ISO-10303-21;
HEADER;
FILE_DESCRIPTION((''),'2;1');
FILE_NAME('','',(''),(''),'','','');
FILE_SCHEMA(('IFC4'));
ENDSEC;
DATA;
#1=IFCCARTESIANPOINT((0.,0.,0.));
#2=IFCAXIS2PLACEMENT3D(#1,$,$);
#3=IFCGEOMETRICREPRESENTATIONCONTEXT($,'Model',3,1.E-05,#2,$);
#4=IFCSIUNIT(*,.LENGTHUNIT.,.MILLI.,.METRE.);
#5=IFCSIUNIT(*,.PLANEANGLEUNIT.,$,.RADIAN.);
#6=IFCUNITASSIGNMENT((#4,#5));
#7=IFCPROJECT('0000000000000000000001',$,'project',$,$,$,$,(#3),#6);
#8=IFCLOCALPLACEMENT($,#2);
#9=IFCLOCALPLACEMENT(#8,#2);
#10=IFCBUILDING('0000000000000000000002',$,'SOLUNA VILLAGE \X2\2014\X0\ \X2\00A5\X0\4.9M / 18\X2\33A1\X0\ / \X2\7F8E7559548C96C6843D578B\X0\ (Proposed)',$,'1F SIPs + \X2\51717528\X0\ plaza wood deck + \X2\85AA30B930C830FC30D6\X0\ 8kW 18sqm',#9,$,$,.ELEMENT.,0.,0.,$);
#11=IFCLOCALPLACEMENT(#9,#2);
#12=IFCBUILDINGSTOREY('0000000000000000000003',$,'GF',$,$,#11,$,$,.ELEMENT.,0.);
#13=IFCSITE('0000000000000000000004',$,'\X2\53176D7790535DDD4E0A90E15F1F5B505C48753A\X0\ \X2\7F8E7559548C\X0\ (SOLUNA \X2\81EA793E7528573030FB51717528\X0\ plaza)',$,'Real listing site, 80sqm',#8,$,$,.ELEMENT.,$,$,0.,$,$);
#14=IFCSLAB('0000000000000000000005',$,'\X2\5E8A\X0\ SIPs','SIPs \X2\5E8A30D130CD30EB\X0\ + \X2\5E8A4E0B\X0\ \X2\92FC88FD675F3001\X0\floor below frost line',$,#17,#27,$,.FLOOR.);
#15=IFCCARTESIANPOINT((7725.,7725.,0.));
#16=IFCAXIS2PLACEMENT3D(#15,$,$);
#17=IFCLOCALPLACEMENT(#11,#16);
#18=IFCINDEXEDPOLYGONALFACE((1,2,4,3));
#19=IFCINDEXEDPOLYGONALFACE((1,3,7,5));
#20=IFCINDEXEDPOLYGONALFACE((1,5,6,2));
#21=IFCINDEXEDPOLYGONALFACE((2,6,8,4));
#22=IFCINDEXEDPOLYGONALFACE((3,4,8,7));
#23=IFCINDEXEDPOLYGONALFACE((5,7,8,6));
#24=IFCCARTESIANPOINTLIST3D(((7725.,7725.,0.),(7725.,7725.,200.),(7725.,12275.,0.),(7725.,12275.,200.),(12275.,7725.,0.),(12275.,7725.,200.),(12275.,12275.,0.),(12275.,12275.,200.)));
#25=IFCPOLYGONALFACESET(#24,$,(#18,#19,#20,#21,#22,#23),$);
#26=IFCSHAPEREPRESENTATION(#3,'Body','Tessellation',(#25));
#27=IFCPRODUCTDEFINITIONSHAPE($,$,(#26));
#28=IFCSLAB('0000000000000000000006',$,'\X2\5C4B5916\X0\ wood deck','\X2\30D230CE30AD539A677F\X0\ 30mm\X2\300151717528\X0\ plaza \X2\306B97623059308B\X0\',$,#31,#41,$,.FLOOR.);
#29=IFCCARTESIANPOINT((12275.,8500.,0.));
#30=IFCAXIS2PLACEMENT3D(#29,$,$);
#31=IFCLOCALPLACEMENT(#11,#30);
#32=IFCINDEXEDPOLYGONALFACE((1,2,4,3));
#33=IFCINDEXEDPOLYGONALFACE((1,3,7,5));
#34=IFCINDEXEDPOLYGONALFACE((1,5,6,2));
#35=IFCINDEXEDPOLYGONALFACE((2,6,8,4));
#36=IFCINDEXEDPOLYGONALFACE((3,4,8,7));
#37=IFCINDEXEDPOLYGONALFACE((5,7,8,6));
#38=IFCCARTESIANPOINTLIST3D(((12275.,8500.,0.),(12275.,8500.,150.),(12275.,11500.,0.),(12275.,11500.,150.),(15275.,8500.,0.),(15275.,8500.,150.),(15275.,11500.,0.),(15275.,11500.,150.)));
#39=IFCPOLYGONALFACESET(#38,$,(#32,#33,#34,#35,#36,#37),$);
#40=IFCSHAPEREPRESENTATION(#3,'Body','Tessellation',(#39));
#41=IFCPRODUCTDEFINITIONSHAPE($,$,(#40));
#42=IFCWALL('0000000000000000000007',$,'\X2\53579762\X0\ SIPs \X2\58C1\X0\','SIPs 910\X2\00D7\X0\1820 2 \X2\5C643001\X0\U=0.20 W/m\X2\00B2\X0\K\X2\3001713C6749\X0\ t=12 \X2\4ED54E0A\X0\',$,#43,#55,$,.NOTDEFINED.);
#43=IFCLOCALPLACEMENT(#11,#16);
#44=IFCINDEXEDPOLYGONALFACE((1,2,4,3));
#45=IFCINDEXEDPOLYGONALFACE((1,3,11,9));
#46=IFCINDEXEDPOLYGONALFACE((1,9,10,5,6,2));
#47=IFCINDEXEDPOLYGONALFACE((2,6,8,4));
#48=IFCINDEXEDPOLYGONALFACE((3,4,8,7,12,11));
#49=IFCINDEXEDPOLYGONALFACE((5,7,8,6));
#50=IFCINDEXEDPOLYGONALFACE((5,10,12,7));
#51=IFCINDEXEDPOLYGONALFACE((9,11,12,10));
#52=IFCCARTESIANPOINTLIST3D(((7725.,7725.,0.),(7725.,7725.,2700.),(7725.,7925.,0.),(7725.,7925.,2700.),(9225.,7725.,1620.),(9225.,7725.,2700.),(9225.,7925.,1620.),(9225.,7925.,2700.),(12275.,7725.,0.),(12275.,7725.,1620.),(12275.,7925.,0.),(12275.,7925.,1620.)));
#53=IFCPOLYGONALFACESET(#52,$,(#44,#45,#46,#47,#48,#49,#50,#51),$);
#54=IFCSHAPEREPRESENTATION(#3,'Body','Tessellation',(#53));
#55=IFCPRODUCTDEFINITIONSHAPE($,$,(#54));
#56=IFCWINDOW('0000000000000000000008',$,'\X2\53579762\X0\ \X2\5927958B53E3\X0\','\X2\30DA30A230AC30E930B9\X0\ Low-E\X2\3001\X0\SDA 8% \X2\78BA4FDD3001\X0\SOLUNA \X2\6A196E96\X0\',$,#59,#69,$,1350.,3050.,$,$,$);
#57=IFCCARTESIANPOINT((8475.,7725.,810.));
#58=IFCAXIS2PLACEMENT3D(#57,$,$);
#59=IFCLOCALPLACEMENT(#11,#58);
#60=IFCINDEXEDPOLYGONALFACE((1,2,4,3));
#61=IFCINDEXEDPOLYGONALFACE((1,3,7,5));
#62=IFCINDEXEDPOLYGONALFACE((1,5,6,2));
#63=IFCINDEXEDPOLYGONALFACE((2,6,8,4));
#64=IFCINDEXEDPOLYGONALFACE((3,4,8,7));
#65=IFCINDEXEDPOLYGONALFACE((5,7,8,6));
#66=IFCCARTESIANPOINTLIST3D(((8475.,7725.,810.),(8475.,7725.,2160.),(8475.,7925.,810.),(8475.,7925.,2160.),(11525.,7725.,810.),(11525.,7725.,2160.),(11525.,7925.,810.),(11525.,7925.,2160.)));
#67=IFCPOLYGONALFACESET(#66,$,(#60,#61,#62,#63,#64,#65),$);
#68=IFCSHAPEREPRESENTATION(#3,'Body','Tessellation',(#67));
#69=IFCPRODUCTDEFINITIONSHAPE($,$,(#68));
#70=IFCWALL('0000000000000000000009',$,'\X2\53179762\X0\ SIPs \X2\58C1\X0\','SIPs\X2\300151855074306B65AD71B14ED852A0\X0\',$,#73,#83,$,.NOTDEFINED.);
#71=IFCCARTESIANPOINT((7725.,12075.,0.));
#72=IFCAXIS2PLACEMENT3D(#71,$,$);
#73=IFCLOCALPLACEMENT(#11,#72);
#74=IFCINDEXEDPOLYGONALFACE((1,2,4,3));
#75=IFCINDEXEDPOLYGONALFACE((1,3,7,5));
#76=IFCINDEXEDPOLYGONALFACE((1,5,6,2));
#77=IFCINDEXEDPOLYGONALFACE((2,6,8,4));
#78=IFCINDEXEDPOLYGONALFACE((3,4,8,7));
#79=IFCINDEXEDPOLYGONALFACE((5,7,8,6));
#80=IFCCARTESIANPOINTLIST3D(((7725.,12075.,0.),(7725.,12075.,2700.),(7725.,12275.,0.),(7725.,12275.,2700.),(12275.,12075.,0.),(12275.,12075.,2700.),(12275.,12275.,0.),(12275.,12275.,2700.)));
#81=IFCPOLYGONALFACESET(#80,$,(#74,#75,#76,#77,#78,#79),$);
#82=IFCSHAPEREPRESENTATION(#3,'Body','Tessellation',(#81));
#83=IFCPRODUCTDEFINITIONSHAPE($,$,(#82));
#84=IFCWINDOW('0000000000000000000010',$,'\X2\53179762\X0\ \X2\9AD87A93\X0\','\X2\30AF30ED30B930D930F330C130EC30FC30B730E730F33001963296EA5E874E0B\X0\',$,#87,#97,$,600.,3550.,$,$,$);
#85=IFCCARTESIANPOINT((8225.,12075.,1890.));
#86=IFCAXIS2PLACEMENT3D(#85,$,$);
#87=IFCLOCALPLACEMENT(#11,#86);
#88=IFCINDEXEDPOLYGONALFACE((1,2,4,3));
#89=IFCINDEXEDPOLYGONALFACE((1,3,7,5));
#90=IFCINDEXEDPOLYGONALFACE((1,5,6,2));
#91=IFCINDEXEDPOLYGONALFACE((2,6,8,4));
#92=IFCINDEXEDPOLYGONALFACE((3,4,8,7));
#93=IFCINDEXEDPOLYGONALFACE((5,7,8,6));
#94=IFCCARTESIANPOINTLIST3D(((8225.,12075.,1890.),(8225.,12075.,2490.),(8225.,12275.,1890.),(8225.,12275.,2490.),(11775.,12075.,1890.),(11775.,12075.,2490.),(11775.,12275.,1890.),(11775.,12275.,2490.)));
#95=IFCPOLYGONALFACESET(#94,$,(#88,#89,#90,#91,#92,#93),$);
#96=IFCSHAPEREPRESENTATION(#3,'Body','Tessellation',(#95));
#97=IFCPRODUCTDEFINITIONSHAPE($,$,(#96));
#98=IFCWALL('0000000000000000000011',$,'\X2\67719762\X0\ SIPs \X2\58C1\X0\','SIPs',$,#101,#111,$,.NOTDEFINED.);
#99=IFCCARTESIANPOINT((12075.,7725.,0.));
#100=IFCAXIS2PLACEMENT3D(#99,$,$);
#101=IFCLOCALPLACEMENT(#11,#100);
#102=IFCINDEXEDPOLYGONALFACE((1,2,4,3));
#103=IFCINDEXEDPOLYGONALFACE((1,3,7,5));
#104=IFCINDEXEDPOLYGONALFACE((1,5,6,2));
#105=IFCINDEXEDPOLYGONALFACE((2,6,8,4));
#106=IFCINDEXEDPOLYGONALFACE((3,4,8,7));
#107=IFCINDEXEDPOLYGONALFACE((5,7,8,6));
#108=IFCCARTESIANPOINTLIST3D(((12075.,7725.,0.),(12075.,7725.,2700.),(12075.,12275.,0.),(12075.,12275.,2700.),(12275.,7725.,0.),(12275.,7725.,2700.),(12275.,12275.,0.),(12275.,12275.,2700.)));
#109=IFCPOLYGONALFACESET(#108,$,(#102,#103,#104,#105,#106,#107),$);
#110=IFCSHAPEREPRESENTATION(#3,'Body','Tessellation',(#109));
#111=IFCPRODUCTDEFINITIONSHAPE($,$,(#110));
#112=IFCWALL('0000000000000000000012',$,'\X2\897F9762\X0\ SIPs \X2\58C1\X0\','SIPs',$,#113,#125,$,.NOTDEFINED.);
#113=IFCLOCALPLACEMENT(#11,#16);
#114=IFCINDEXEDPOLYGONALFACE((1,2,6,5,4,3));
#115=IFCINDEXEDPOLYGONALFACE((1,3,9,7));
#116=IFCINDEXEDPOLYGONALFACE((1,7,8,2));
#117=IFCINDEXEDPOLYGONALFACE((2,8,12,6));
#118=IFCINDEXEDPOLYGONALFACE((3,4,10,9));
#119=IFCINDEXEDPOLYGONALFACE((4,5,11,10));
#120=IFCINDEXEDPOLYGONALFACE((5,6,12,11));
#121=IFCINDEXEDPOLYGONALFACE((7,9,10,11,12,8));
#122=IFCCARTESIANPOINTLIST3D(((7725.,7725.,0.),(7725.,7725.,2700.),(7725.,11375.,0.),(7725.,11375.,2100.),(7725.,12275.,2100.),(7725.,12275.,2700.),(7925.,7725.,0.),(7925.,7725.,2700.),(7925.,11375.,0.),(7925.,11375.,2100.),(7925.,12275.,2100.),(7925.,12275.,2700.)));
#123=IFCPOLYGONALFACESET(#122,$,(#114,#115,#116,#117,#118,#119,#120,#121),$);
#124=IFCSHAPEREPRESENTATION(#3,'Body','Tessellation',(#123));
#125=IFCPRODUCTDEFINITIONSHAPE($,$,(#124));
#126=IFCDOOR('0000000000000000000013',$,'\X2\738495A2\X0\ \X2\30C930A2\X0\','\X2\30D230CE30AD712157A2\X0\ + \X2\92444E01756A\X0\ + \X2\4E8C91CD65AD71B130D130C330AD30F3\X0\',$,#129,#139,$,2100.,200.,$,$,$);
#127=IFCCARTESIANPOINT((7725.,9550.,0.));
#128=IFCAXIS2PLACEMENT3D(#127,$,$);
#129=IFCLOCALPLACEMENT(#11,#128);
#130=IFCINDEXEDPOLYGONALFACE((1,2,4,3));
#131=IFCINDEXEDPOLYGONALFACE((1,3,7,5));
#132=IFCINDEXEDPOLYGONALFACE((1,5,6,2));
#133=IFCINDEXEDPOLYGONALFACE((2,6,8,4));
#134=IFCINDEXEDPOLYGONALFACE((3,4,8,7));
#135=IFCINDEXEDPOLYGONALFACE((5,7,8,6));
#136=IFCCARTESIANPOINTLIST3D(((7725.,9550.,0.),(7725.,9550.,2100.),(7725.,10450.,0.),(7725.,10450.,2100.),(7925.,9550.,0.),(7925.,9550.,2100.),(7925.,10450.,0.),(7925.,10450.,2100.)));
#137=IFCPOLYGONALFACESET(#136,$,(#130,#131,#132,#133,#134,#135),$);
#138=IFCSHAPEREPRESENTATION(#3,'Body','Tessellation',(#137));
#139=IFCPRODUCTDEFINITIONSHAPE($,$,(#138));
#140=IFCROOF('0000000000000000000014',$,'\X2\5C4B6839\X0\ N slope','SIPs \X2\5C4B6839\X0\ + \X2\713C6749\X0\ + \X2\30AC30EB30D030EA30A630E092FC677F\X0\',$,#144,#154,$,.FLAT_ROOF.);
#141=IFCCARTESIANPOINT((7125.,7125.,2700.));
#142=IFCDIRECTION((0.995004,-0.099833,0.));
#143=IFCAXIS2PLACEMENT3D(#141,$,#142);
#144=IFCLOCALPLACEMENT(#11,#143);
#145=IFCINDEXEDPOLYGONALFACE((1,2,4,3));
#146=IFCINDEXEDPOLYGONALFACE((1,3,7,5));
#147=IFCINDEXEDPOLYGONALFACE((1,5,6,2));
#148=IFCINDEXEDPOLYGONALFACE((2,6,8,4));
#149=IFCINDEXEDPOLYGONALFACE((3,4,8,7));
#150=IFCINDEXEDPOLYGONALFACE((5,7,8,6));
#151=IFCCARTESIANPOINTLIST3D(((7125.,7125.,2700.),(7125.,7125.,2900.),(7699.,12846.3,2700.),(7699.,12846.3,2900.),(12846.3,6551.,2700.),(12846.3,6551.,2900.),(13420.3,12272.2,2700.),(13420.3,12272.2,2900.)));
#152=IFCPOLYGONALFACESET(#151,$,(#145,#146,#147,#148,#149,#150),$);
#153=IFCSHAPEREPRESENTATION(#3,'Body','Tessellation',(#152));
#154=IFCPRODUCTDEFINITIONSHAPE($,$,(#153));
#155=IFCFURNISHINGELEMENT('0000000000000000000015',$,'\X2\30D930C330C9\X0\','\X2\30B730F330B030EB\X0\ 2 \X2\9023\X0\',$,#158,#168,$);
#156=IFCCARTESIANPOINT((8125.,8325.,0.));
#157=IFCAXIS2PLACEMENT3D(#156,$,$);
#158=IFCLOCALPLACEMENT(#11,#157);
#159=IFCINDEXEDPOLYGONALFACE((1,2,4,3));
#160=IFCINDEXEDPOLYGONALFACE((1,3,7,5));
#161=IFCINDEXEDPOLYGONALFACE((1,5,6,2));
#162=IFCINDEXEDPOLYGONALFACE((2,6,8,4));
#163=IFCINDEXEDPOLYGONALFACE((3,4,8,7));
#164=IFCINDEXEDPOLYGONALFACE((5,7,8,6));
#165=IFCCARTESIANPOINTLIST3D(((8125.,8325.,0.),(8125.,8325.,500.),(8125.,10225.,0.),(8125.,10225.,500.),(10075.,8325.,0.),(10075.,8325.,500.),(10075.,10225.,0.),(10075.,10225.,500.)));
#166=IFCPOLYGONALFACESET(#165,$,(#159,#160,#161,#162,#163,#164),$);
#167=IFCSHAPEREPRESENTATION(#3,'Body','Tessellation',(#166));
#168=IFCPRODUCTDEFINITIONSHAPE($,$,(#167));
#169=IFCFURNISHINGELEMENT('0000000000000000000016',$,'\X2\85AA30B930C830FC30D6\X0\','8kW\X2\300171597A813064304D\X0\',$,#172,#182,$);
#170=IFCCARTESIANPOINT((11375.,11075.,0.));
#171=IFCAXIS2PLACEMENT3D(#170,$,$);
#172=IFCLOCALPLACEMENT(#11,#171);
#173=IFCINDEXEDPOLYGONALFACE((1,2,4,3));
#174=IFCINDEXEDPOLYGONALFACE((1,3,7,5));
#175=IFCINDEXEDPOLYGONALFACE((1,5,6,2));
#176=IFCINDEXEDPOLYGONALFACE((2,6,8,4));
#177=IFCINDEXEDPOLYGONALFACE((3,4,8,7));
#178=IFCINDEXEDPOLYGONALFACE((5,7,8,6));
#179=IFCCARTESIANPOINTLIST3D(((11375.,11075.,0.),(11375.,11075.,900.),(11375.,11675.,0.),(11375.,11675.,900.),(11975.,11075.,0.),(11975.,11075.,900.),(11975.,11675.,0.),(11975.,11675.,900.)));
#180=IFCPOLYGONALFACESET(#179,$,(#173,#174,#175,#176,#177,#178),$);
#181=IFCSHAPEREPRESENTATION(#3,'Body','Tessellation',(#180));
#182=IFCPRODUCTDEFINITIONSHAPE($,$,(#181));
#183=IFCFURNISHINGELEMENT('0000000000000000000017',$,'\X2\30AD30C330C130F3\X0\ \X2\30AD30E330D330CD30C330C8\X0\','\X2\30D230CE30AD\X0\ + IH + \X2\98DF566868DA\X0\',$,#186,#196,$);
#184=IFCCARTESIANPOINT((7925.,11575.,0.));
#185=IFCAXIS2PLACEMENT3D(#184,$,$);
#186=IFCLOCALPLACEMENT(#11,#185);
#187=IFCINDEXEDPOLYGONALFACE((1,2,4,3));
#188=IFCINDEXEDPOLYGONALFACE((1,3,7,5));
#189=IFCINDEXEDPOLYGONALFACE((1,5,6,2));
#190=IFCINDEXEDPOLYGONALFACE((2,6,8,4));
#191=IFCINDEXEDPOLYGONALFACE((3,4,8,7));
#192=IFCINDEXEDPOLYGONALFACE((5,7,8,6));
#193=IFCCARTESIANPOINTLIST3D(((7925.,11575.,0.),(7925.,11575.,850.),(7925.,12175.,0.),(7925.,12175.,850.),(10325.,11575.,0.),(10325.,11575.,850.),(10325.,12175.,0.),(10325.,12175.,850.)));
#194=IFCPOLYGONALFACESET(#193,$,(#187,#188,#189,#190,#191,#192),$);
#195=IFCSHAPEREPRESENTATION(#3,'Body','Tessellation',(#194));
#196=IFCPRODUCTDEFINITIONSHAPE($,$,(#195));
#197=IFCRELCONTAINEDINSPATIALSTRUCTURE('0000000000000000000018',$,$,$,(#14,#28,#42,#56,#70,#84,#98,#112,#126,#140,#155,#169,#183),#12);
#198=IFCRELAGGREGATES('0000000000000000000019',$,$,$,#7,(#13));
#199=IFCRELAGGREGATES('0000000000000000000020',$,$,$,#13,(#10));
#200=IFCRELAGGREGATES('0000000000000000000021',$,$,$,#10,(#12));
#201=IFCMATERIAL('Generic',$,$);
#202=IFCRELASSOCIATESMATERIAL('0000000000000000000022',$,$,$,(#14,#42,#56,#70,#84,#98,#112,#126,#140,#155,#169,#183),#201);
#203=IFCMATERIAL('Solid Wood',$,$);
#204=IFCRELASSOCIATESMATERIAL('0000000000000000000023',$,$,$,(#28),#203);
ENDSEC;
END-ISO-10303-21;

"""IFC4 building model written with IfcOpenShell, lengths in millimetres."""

from ifc_helpers import new_model, si_unit, frame, frame_2d, origin, place, context, project, spatial, rectangle, extrude, material, element, fill, save


model = new_model("IFC4")

# Units and contexts
model_context = context("Model", 3, precision=1e-05, world=origin())
ifc_project = project(units=[si_unit("LENGTHUNIT", "METRE", prefix="MILLI"), si_unit("PLANEANGLEUNIT", "RADIAN")], contexts=[model_context])

# Site, building, storey
site_placement = place(None, origin())
site = spatial("IfcSite", under=ifc_project, at=site_placement, Name="北海道川上郡弟子屈町 美留和 (SOLUNA 自社用地・共用 plaza)", ObjectType="Real listing site, 80sqm", CompositionType="ELEMENT", RefElevation=0.0)
building_placement = place(site_placement, origin())
building = spatial("IfcBuilding", under=site, at=building_placement, Name="SOLUNA VILLAGE — ¥4.9M / 18㎡ / 美留和集落型 (Proposed)", ObjectType="1F SIPs + 共用 plaza wood deck + 薪ストーブ 8kW 18sqm", CompositionType="ELEMENT", ElevationOfRefHeight=0.0, ElevationOfTerrain=0.0)
storey_placement = place(building_placement, origin())
storey = spatial("IfcBuildingStorey", under=building, at=storey_placement, Name="GF", CompositionType="ELEMENT", Elevation=0.0)

# Slabs
ifc_material_1 = material(Name="Generic")
slab_1_placement = place(storey_placement, frame((7725.0, 7725.0, 0.0)))
element("IfcSlab", 1, at=slab_1_placement, inside=storey, material=ifc_material_1, Name="床 SIPs", Description="SIPs 床パネル + 床下 鋼製束、floor below frost line", PredefinedType="FLOOR", context=model_context, shape_type="SweptSolid", body=[
    extrude(rectangle(XDim=4550.0, YDim=4550.0, at=frame_2d((2275.0, 2275.0))), frame((7725.0, 7725.0, 0.0)), (0.0, 0.0, 1.0), 200.0),
])
ifc_material_2 = material(Name="Solid Wood")
slab_2_placement = place(storey_placement, frame((12275.0, 8500.0, 0.0)))
element("IfcSlab", 2, at=slab_2_placement, inside=storey, material=ifc_material_2, Name="屋外 wood deck", Description="ヒノキ厚板 30mm、共用 plaza に面する", PredefinedType="FLOOR", context=model_context, shape_type="SweptSolid", body=[
    extrude(rectangle(XDim=3000.0, YDim=3000.0, at=frame_2d((1500.0, 1500.0))), frame((12275.0, 8500.0, 0.0)), (0.0, 0.0, 1.0), 150.0),
])

# Walls, openings, windows
wall_1_placement = place(storey_placement, frame((7725.0, 7725.0, 0.0)))
wall_1 = element("IfcWall", 3, at=wall_1_placement, inside=storey, material=ifc_material_1, Name="南面 SIPs 壁", Description="SIPs 910×1820 2 層、U=0.20 W/m²K、焼杉 t=12 仕上", PredefinedType="NOTDEFINED", context=model_context, shape_type="SweptSolid", body=[
    extrude(rectangle(XDim=4550.0, YDim=200.0, at=frame_2d((2275.0, 100.0))), frame((7725.0, 7725.0, 0.0)), (0.0, 0.0, 1.0), 2700.0),
])
opening_1_placement = place(storey_placement, frame((8475.0, 7725.0, 810.0)))
opening_1 = element("IfcOpeningElement", 4, at=opening_1_placement, cuts=wall_1, PredefinedType="NOTDEFINED", context=model_context, shape_type="SweptSolid", body=[
    extrude(rectangle(XDim=3050.0, YDim=200.0, at=frame_2d((1525.0, 100.0))), frame((8475.0, 7725.0, 810.0)), (0.0, 0.0, 1.0), 1350.0),
])
window_1_placement = place(storey_placement, frame((8475.0, 7725.0, 810.0)))
window_1 = element("IfcWindow", 5, at=window_1_placement, inside=storey, material=ifc_material_1, Name="南面 大開口", Description="ペアガラス Low-E、SDA 8% 確保、SOLUNA 標準", OverallHeight=1350.0, OverallWidth=3050.0, context=model_context, shape_type="SweptSolid", body=[
    extrude(rectangle(XDim=3050.0, YDim=200.0, at=frame_2d((1525.0, 100.0))), frame((8475.0, 7725.0, 810.0)), (0.0, 0.0, 1.0), 1350.0),
])
fill(opening_1, window_1)
wall_2_placement = place(storey_placement, frame((7725.0, 12075.0, 0.0)))
wall_2 = element("IfcWall", 6, at=wall_2_placement, inside=storey, material=ifc_material_1, Name="北面 SIPs 壁", Description="SIPs、内側に断熱付加", PredefinedType="NOTDEFINED", context=model_context, shape_type="SweptSolid", body=[
    extrude(rectangle(XDim=4550.0, YDim=200.0, at=frame_2d((2275.0, 100.0))), frame((7725.0, 12075.0, 0.0)), (0.0, 0.0, 1.0), 2700.0),
])
opening_2_placement = place(storey_placement, frame((8225.0, 12075.0, 1890.0)))
opening_2 = element("IfcOpeningElement", 7, at=opening_2_placement, cuts=wall_2, PredefinedType="NOTDEFINED", context=model_context, shape_type="SweptSolid", body=[
    extrude(rectangle(XDim=3550.0, YDim=200.0, at=frame_2d((1775.0, 100.0))), frame((8225.0, 12075.0, 1890.0)), (0.0, 0.0, 1.0), 600.0),
])
window_2_placement = place(storey_placement, frame((8225.0, 12075.0, 1890.0)))
window_2 = element("IfcWindow", 8, at=window_2_placement, inside=storey, material=ifc_material_1, Name="北面 高窓", Description="クロスベンチレーション、防雪庇下", OverallHeight=600.0, OverallWidth=3550.0, context=model_context, shape_type="SweptSolid", body=[
    extrude(rectangle(XDim=3550.0, YDim=200.0, at=frame_2d((1775.0, 100.0))), frame((8225.0, 12075.0, 1890.0)), (0.0, 0.0, 1.0), 600.0),
])
fill(opening_2, window_2)

# Wall
wall_3_placement = place(storey_placement, frame((12075.0, 7725.0, 0.0)))
element("IfcWall", 9, at=wall_3_placement, inside=storey, material=ifc_material_1, Name="東面 SIPs 壁", Description="SIPs", PredefinedType="NOTDEFINED", context=model_context, shape_type="SweptSolid", body=[
    extrude(rectangle(XDim=200.0, YDim=4550.0, at=frame_2d((100.0, 2275.0))), frame((12075.0, 7725.0, 0.0)), (0.0, 0.0, 1.0), 2700.0),
])

# Wall, opening, door
wall_4_placement = place(storey_placement, frame((7725.0, 7725.0, 0.0)))
wall_4 = element("IfcWall", 10, at=wall_4_placement, inside=storey, material=ifc_material_1, Name="西面 SIPs 壁", Description="SIPs", PredefinedType="NOTDEFINED", context=model_context, shape_type="SweptSolid", body=[
    extrude(rectangle(XDim=200.0, YDim=4550.0, at=frame_2d((100.0, 2275.0))), frame((7725.0, 7725.0, 0.0)), (0.0, 0.0, 1.0), 2700.0),
])
opening_3_placement = place(storey_placement, frame((7725.0, 9550.0, 0.0)))
opening_3 = element("IfcOpeningElement", 11, at=opening_3_placement, cuts=wall_4, PredefinedType="NOTDEFINED", context=model_context, shape_type="SweptSolid", body=[
    extrude(rectangle(XDim=200.0, YDim=900.0, at=frame_2d((100.0, 450.0))), frame((7725.0, 9550.0, 0.0)), (0.0, 0.0, 1.0), 2100.0),
])
door_placement = place(storey_placement, frame((7725.0, 9550.0, 0.0)))
door = element("IfcDoor", 12, at=door_placement, inside=storey, material=ifc_material_1, Name="玄関 ドア", Description="ヒノキ無垢 + 鉄丁番 + 二重断熱パッキン", OverallHeight=2100.0, OverallWidth=200.0, context=model_context, shape_type="SweptSolid", body=[
    extrude(rectangle(XDim=200.0, YDim=900.0, at=frame_2d((100.0, 450.0))), frame((7725.0, 9550.0, 0.0)), (0.0, 0.0, 1.0), 2100.0),
])
fill(opening_3, door)

# Roof
roof_placement = place(storey_placement, frame((7125.0, 7125.0, 2700.0), x_axis=(0.995004, -0.099833, 0.0)))
element("IfcRoof", 13, at=roof_placement, inside=storey, material=ifc_material_1, Name="屋根 N slope", Description="SIPs 屋根 + 焼杉 + ガルバリウム鋼板", PredefinedType="FLAT_ROOF", context=model_context, shape_type="SweptSolid", body=[
    extrude(rectangle(XDim=5750.0, YDim=5750.0, at=frame_2d((2875.0, 2875.0))), frame((7125.0, 7125.0, 2700.0), x_axis=(0.995004, -0.099833, 0.0)), (0.0, 0.0, 1.0), 200.0),
])

# Furnishing elements
furnishing_1_placement = place(storey_placement, frame((8125.0, 8325.0, 0.0)))
element("IfcFurnishingElement", 14, at=furnishing_1_placement, inside=storey, material=ifc_material_1, Name="ベッド", Description="シングル 2 連", context=model_context, shape_type="SweptSolid", body=[
    extrude(rectangle(XDim=1950.0, YDim=1900.0, at=frame_2d((975.0, 950.0))), frame((8125.0, 8325.0, 0.0)), (0.0, 0.0, 1.0), 500.0),
])
furnishing_2_placement = place(storey_placement, frame((11375.0, 11075.0, 0.0)))
element("IfcFurnishingElement", 15, at=furnishing_2_placement, inside=storey, material=ifc_material_1, Name="薪ストーブ", Description="8kW、煙突つき", context=model_context, shape_type="SweptSolid", body=[
    extrude(rectangle(XDim=600.0, YDim=600.0, at=frame_2d((300.0, 300.0))), frame((11375.0, 11075.0, 0.0)), (0.0, 0.0, 1.0), 900.0),
])
furnishing_3_placement = place(storey_placement, frame((7925.0, 11575.0, 0.0)))
element("IfcFurnishingElement", 16, at=furnishing_3_placement, inside=storey, material=ifc_material_1, Name="キッチン キャビネット", Description="ヒノキ + IH + 食器棚", context=model_context, shape_type="SweptSolid", body=[
    extrude(rectangle(XDim=2400.0, YDim=600.0, at=frame_2d((1200.0, 300.0))), frame((7925.0, 11575.0, 0.0)), (0.0, 0.0, 1.0), 850.0),
])

save(model, "model.ifc")
